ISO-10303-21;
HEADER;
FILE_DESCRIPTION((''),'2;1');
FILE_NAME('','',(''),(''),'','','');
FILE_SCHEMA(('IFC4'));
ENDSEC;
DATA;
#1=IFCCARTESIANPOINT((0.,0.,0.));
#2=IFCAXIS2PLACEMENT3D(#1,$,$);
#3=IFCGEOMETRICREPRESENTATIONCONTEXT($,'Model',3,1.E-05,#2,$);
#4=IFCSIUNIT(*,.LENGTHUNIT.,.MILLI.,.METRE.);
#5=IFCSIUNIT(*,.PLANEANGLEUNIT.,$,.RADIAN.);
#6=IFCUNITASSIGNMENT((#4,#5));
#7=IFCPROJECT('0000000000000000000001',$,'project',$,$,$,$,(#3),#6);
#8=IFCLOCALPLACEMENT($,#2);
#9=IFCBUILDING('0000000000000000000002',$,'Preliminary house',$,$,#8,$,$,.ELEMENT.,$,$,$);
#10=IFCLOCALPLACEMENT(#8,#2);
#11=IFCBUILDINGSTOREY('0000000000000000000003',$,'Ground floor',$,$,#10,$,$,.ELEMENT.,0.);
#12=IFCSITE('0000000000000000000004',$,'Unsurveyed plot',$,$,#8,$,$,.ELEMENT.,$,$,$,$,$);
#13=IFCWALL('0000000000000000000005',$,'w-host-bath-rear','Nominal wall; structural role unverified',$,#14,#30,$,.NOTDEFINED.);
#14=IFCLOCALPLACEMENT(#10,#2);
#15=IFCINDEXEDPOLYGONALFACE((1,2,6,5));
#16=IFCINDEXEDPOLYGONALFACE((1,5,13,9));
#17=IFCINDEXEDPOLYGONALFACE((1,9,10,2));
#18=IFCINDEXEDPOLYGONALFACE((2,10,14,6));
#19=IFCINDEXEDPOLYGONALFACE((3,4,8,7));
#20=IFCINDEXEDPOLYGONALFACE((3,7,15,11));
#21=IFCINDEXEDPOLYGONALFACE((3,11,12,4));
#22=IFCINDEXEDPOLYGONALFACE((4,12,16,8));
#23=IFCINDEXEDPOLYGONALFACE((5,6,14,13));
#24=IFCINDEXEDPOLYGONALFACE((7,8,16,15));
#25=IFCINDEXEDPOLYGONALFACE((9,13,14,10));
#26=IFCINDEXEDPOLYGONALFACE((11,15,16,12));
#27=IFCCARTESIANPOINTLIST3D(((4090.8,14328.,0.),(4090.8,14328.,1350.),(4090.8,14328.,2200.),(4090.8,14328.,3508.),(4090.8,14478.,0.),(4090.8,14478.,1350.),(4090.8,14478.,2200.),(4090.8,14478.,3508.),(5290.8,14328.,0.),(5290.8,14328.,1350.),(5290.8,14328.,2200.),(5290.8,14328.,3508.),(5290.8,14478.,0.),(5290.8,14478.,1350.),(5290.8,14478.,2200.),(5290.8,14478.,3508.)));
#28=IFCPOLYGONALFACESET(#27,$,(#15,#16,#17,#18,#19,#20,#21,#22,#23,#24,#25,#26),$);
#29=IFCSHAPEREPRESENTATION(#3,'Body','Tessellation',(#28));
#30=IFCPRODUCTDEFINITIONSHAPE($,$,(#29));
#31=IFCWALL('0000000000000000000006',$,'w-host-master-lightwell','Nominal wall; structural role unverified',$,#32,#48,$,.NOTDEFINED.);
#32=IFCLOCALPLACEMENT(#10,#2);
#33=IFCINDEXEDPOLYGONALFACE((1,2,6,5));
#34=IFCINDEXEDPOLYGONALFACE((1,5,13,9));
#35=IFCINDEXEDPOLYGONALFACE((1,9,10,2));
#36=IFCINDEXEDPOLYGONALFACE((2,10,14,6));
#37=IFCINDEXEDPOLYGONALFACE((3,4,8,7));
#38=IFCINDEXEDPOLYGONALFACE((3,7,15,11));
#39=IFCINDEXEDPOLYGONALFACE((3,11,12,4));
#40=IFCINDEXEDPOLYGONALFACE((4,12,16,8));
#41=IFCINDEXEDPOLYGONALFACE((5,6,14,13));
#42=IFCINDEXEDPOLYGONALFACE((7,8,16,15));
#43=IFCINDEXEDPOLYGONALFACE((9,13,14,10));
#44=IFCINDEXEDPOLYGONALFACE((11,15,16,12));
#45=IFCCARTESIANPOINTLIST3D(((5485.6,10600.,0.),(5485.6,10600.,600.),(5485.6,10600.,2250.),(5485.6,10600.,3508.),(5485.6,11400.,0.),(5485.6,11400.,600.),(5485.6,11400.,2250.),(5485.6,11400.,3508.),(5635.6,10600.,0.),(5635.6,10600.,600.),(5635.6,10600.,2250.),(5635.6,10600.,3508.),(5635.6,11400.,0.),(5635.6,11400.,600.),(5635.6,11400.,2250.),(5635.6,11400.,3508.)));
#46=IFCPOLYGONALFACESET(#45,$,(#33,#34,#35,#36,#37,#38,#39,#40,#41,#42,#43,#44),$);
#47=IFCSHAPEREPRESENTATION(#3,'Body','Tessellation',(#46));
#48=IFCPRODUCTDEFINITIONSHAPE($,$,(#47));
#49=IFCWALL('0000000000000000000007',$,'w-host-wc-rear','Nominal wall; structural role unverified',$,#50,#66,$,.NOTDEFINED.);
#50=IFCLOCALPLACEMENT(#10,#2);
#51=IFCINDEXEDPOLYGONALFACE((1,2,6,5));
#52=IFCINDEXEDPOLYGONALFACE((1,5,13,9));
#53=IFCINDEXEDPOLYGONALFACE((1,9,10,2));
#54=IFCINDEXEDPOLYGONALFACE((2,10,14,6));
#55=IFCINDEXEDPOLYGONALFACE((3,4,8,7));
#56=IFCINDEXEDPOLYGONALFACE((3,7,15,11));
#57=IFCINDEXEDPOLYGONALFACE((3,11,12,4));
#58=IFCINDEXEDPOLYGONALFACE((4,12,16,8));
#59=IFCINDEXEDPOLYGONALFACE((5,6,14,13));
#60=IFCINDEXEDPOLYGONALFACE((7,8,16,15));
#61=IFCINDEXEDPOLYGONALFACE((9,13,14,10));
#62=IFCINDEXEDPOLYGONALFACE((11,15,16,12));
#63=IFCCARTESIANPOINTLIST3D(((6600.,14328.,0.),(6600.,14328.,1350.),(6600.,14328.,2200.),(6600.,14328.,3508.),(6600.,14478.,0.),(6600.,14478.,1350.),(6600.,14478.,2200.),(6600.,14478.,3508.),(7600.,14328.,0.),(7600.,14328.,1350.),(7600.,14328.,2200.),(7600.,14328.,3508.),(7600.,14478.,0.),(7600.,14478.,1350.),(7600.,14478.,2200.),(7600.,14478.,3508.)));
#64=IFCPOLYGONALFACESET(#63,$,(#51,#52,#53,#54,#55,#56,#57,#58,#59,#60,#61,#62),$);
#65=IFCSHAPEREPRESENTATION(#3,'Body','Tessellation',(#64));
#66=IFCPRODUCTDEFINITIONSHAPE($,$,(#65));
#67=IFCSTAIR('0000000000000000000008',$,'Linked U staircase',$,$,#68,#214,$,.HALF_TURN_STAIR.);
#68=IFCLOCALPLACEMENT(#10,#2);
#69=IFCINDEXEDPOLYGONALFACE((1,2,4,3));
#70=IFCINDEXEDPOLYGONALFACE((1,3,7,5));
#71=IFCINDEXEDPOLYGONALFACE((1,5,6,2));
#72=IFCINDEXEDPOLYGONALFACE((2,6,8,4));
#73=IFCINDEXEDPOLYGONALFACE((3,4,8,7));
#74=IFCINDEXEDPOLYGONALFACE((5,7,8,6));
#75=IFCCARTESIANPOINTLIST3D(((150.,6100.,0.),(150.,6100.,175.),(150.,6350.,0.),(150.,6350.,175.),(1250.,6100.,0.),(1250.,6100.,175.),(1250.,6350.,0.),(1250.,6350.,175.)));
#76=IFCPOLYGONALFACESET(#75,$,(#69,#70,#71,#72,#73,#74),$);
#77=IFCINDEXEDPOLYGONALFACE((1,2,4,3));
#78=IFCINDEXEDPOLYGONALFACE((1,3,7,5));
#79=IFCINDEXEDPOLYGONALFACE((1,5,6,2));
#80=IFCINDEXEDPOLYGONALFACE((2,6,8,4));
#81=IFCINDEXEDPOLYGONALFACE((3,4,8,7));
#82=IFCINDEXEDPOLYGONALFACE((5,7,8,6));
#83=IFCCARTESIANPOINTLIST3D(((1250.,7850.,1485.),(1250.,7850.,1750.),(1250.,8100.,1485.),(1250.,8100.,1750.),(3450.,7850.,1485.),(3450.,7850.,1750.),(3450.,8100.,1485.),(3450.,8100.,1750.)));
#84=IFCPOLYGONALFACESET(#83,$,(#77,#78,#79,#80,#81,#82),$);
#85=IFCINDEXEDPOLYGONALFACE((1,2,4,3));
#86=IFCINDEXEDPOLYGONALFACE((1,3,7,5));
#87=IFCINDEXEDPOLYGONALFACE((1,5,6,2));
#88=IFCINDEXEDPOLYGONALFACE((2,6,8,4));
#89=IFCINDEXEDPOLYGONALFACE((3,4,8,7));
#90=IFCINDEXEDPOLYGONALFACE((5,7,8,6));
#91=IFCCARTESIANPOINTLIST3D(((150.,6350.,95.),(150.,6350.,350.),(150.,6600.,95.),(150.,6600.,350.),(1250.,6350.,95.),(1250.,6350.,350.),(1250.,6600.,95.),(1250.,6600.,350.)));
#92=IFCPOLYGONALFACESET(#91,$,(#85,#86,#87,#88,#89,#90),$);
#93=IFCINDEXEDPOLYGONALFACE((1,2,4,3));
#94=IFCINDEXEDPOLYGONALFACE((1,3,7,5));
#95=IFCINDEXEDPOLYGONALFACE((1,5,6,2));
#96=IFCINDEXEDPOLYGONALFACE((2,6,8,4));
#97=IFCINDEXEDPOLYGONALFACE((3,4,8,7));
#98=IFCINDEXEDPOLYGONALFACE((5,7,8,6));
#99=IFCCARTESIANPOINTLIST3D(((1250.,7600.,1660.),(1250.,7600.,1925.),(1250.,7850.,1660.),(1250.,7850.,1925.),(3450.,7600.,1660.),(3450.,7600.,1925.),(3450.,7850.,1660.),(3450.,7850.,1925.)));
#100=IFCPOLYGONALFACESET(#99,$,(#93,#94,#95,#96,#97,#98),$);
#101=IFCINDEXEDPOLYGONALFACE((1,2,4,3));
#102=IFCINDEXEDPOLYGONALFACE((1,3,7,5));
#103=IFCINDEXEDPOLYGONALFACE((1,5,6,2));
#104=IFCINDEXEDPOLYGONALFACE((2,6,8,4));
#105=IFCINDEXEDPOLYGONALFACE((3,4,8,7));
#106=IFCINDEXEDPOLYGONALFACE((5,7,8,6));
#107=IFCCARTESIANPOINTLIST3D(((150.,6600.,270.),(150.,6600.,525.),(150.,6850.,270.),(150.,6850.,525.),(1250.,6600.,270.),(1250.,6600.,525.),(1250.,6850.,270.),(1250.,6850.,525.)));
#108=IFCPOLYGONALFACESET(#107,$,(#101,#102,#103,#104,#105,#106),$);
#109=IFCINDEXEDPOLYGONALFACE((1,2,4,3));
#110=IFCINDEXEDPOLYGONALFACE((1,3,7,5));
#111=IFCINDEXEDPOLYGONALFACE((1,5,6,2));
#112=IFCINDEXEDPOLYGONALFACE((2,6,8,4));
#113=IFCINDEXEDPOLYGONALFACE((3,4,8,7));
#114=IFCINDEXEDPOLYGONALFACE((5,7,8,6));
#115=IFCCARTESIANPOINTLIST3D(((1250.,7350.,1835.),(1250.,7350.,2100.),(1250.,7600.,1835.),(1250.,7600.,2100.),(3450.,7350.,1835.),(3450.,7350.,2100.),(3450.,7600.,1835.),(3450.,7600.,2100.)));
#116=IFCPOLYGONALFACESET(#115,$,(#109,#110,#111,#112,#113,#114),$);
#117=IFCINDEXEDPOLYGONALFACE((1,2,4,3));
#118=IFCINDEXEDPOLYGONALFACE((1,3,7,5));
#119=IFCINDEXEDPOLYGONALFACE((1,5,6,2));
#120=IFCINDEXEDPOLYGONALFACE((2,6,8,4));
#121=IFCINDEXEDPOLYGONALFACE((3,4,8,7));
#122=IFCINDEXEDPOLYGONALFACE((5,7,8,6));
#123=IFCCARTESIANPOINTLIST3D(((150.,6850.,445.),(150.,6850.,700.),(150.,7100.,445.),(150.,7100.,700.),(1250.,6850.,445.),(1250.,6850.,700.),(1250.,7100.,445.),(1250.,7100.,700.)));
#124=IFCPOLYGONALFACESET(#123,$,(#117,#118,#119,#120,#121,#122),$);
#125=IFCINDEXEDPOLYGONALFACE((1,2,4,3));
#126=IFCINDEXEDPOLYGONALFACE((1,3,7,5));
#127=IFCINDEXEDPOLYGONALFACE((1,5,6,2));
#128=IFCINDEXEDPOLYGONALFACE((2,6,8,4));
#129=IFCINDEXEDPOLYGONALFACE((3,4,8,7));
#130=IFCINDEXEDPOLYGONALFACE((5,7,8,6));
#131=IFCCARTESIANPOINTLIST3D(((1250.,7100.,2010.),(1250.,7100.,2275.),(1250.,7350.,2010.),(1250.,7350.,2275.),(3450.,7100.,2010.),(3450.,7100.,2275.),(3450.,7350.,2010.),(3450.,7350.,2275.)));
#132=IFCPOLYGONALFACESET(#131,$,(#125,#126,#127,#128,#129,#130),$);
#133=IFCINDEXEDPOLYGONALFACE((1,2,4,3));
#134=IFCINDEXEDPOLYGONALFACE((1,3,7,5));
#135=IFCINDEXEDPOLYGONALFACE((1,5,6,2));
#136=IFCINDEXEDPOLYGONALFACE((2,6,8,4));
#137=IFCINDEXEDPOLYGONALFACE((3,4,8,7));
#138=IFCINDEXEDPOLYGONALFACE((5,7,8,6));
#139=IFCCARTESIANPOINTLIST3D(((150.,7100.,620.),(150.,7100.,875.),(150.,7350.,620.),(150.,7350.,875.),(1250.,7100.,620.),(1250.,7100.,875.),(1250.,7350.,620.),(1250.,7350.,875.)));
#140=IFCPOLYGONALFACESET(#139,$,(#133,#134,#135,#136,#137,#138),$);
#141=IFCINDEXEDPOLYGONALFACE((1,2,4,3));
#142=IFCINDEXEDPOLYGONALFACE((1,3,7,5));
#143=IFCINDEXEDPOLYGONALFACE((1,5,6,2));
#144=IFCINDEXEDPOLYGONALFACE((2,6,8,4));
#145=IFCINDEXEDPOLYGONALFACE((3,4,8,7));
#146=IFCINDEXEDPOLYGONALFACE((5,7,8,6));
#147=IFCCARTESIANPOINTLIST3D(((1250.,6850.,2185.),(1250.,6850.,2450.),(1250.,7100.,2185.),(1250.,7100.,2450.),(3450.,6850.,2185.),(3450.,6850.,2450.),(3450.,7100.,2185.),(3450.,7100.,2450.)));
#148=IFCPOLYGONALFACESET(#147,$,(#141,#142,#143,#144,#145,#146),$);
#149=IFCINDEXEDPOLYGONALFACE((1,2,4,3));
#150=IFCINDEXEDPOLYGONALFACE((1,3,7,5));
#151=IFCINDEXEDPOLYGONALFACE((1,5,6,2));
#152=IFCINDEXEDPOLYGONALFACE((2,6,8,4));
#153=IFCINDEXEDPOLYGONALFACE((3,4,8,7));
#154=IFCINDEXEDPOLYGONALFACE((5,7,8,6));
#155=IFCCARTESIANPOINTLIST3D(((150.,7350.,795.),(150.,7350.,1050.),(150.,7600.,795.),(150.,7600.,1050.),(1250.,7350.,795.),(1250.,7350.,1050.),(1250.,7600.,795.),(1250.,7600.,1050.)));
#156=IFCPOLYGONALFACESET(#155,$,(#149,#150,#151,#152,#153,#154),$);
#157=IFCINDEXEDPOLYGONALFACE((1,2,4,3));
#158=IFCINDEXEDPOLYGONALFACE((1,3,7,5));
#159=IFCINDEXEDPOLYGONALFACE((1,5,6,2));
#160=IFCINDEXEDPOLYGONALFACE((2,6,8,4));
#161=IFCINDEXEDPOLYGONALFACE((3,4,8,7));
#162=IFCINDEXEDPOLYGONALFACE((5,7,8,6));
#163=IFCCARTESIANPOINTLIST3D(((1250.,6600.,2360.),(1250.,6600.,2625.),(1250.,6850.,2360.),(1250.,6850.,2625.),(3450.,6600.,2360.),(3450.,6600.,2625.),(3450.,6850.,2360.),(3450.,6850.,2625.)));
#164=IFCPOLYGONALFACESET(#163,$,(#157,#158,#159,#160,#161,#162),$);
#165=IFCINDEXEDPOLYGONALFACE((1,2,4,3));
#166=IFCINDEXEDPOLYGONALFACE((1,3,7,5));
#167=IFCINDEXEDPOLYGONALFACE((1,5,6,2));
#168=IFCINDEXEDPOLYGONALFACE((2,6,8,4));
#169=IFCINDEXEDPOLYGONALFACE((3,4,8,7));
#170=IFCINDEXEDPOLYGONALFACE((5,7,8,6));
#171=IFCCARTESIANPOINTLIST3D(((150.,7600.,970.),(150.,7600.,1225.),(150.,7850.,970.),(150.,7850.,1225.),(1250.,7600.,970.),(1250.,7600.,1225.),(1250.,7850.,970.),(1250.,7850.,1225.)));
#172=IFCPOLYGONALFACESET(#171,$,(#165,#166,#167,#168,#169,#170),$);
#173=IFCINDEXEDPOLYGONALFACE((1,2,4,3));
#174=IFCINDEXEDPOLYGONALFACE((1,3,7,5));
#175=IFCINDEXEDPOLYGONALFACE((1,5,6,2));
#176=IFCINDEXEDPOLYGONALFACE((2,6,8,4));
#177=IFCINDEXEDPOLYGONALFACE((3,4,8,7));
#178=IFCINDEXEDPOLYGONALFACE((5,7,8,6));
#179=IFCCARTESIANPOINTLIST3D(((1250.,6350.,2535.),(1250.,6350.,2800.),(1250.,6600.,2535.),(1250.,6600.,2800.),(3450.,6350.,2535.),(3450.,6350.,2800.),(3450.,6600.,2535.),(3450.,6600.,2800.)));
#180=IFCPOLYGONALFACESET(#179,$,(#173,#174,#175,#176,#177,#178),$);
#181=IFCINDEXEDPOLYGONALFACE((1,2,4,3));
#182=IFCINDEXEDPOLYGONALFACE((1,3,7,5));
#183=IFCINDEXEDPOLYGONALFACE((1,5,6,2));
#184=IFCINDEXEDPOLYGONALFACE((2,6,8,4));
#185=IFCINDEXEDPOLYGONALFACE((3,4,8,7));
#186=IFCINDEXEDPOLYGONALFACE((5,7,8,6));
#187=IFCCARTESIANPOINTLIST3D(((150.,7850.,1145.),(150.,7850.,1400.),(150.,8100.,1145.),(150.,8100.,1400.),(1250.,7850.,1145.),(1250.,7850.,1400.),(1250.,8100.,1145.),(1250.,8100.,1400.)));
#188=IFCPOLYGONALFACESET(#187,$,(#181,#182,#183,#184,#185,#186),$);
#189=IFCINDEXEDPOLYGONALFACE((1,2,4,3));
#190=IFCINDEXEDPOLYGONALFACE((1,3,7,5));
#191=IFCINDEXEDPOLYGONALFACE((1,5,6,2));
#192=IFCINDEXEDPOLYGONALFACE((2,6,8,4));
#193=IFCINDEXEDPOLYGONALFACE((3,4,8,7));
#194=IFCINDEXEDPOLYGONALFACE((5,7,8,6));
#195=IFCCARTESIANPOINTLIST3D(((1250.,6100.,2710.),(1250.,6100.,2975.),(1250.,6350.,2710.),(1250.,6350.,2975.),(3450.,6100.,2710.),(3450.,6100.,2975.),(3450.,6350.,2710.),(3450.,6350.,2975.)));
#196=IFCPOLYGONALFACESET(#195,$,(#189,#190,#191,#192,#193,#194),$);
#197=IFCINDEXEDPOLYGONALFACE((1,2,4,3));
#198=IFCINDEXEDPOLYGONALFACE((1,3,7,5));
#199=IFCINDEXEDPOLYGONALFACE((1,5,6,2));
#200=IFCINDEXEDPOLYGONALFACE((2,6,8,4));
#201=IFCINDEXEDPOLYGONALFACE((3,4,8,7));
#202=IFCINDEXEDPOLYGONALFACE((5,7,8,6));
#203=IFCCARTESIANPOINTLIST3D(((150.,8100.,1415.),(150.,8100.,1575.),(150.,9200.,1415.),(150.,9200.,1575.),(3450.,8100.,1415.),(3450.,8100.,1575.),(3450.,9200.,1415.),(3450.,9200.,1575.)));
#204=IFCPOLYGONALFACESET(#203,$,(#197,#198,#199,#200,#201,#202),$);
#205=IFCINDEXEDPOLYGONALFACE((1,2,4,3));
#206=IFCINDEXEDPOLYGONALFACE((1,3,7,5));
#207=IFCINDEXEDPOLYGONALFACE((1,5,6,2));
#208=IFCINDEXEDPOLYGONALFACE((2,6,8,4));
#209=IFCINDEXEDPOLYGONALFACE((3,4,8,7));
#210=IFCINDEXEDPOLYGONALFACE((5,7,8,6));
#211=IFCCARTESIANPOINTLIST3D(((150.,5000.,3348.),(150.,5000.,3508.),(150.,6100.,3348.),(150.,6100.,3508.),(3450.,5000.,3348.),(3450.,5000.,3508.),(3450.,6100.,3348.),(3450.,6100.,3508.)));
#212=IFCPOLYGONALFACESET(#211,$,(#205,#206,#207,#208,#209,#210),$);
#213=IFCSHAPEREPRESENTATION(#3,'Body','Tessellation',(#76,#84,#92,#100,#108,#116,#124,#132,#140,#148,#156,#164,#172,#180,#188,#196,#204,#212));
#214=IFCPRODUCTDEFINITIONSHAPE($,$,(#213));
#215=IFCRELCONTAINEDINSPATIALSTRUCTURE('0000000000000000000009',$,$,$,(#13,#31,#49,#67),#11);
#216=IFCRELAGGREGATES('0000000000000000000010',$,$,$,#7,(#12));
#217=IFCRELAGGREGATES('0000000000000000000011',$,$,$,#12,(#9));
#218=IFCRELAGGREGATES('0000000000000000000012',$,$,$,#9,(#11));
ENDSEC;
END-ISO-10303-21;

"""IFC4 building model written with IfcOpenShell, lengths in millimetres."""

from ifc_helpers import new_model, si_unit, frame, origin, place, context, project, spatial, polyline, outline, extrude, element, save


model = new_model("IFC4")

# Units and contexts
model_context = context("Model", 3, precision=1e-05, world=origin())
ifc_project = project(units=[si_unit("LENGTHUNIT", "METRE", prefix="MILLI"), si_unit("PLANEANGLEUNIT", "RADIAN")], contexts=[model_context])

# Site, building, storey
placement_1 = place(None, origin())
site = spatial("IfcSite", under=ifc_project, at=placement_1, Name="Unsurveyed plot", CompositionType="ELEMENT")
building = spatial("IfcBuilding", under=site, at=placement_1, Name="Preliminary house", CompositionType="ELEMENT")
placement_2 = place(placement_1, origin())
storey = spatial("IfcBuildingStorey", under=building, at=placement_2, Name="Ground floor", CompositionType="ELEMENT", Elevation=0.0)

# Walls, openings
wall_1 = element("IfcWall", 1, at=placement_2, inside=storey, Name="w-host-bath-rear", Description="Nominal wall; structural role unverified", PredefinedType="NOTDEFINED", context=model_context, shape_type="SweptSolid", body=[
    extrude(outline(polyline([(4090.8, 14328.0), (5290.8, 14328.0), (5290.8, 14478.0), (4090.8, 14478.0), (4090.8, 14328.0)])), origin(), (0.0, 0.0, 1.0), 3508.0),
])
element("IfcOpeningElement", 2, at=placement_2, cuts=wall_1, PredefinedType="OPENING", context=model_context, shape_type="SweptSolid", body=[
    extrude(outline(polyline([(4090.8, 13953.0), (5290.8, 13953.0), (5290.8, 14853.0), (4090.8, 14853.0), (4090.8, 13953.0)])), frame((0.0, 0.0, 1350.0)), (0.0, 0.0, 1.0), 850.0),
])
wall_2 = element("IfcWall", 3, at=placement_2, inside=storey, Name="w-host-master-lightwell", Description="Nominal wall; structural role unverified", PredefinedType="NOTDEFINED", context=model_context, shape_type="SweptSolid", body=[
    extrude(outline(polyline([(5635.6, 10600.0), (5635.6, 11400.0), (5485.6, 11400.0), (5485.6, 10600.0), (5635.6, 10600.0)])), origin(), (0.0, 0.0, 1.0), 3508.0),
])
element("IfcOpeningElement", 4, at=placement_2, cuts=wall_2, PredefinedType="OPENING", context=model_context, shape_type="SweptSolid", body=[
    extrude(outline(polyline([(6010.6, 10600.0), (6010.6, 11400.0), (5110.6, 11400.0), (5110.6, 10600.0), (6010.6, 10600.0)])), frame((0.0, 0.0, 600.0)), (0.0, 0.0, 1.0), 1650.0),
])
wall_3 = element("IfcWall", 5, at=placement_2, inside=storey, Name="w-host-wc-rear", Description="Nominal wall; structural role unverified", PredefinedType="NOTDEFINED", context=model_context, shape_type="SweptSolid", body=[
    extrude(outline(polyline([(6600.0, 14328.0), (7600.0, 14328.0), (7600.0, 14478.0), (6600.0, 14478.0), (6600.0, 14328.0)])), origin(), (0.0, 0.0, 1.0), 3508.0),
])
element("IfcOpeningElement", 6, at=placement_2, cuts=wall_3, PredefinedType="OPENING", context=model_context, shape_type="SweptSolid", body=[
    extrude(outline(polyline([(6600.0, 13953.0), (7600.0, 13953.0), (7600.0, 14853.0), (6600.0, 14853.0), (6600.0, 13953.0)])), frame((0.0, 0.0, 1350.0)), (0.0, 0.0, 1.0), 850.0),
])

# Stair
element("IfcStair", 7, at=placement_2, inside=storey, Name="Linked U staircase", PredefinedType="HALF_TURN_STAIR", context=model_context, shape_type="SweptSolid", body=[
    extrude(outline(polyline([(1250.0, 6100.0), (1250.0, 6350.0), (150.0, 6350.0), (150.0, 6100.0), (1250.0, 6100.0)])), origin(), (0.0, 0.0, 1.0), 175.0),
    extrude(outline(polyline([(3450.0, 7850.0), (3450.0, 8100.0), (1250.0, 8100.0), (1250.0, 7850.0), (3450.0, 7850.0)])), frame((0.0, 0.0, 1485.0)), (0.0, 0.0, 1.0), 265.0),
    extrude(outline(polyline([(1250.0, 6350.0), (1250.0, 6600.0), (150.0, 6600.0), (150.0, 6350.0), (1250.0, 6350.0)])), frame((0.0, 0.0, 95.0)), (0.0, 0.0, 1.0), 255.0),
    extrude(outline(polyline([(3450.0, 7600.0), (3450.0, 7850.0), (1250.0, 7850.0), (1250.0, 7600.0), (3450.0, 7600.0)])), frame((0.0, 0.0, 1660.0)), (0.0, 0.0, 1.0), 265.0),
    extrude(outline(polyline([(1250.0, 6600.0), (1250.0, 6850.0), (150.0, 6850.0), (150.0, 6600.0), (1250.0, 6600.0)])), frame((0.0, 0.0, 270.0)), (0.0, 0.0, 1.0), 255.0),
    extrude(outline(polyline([(3450.0, 7350.0), (3450.0, 7600.0), (1250.0, 7600.0), (1250.0, 7350.0), (3450.0, 7350.0)])), frame((0.0, 0.0, 1835.0)), (0.0, 0.0, 1.0), 265.0),
    extrude(outline(polyline([(1250.0, 6850.0), (1250.0, 7100.0), (150.0, 7100.0), (150.0, 6850.0), (1250.0, 6850.0)])), frame((0.0, 0.0, 445.0)), (0.0, 0.0, 1.0), 255.0),
    extrude(outline(polyline([(3450.0, 7100.0), (3450.0, 7350.0), (1250.0, 7350.0), (1250.0, 7100.0), (3450.0, 7100.0)])), frame((0.0, 0.0, 2010.0)), (0.0, 0.0, 1.0), 265.0),
    extrude(outline(polyline([(1250.0, 7100.0), (1250.0, 7350.0), (150.0, 7350.0), (150.0, 7100.0), (1250.0, 7100.0)])), frame((0.0, 0.0, 620.0)), (0.0, 0.0, 1.0), 255.0),
    extrude(outline(polyline([(3450.0, 6850.0), (3450.0, 7100.0), (1250.0, 7100.0), (1250.0, 6850.0), (3450.0, 6850.0)])), frame((0.0, 0.0, 2185.0)), (0.0, 0.0, 1.0), 265.0),
    extrude(outline(polyline([(1250.0, 7350.0), (1250.0, 7600.0), (150.0, 7600.0), (150.0, 7350.0), (1250.0, 7350.0)])), frame((0.0, 0.0, 795.0)), (0.0, 0.0, 1.0), 255.0),
    extrude(outline(polyline([(3450.0, 6600.0), (3450.0, 6850.0), (1250.0, 6850.0), (1250.0, 6600.0), (3450.0, 6600.0)])), frame((0.0, 0.0, 2360.0)), (0.0, 0.0, 1.0), 265.0),
    extrude(outline(polyline([(1250.0, 7600.0), (1250.0, 7850.0), (150.0, 7850.0), (150.0, 7600.0), (1250.0, 7600.0)])), frame((0.0, 0.0, 970.0)), (0.0, 0.0, 1.0), 255.0),
    extrude(outline(polyline([(3450.0, 6350.0), (3450.0, 6600.0), (1250.0, 6600.0), (1250.0, 6350.0), (3450.0, 6350.0)])), frame((0.0, 0.0, 2535.0)), (0.0, 0.0, 1.0), 265.0),
    extrude(outline(polyline([(1250.0, 7850.0), (1250.0, 8100.0), (150.0, 8100.0), (150.0, 7850.0), (1250.0, 7850.0)])), frame((0.0, 0.0, 1145.0)), (0.0, 0.0, 1.0), 255.0),
    extrude(outline(polyline([(3450.0, 6100.0), (3450.0, 6350.0), (1250.0, 6350.0), (1250.0, 6100.0), (3450.0, 6100.0)])), frame((0.0, 0.0, 2710.0)), (0.0, 0.0, 1.0), 265.0),
    extrude(outline(polyline([(3450.0, 8100.0), (3450.0, 9200.0), (150.0, 9200.0), (150.0, 8100.0), (3450.0, 8100.0)])), frame((0.0, 0.0, 1415.0)), (0.0, 0.0, 1.0), 160.0),
    extrude(outline(polyline([(3450.0, 5000.0), (3450.0, 6100.0), (150.0, 6100.0), (150.0, 5000.0), (3450.0, 5000.0)])), frame((0.0, 0.0, 3348.0)), (0.0, 0.0, 1.0), 160.0),
])

save(model, "model.ifc")
